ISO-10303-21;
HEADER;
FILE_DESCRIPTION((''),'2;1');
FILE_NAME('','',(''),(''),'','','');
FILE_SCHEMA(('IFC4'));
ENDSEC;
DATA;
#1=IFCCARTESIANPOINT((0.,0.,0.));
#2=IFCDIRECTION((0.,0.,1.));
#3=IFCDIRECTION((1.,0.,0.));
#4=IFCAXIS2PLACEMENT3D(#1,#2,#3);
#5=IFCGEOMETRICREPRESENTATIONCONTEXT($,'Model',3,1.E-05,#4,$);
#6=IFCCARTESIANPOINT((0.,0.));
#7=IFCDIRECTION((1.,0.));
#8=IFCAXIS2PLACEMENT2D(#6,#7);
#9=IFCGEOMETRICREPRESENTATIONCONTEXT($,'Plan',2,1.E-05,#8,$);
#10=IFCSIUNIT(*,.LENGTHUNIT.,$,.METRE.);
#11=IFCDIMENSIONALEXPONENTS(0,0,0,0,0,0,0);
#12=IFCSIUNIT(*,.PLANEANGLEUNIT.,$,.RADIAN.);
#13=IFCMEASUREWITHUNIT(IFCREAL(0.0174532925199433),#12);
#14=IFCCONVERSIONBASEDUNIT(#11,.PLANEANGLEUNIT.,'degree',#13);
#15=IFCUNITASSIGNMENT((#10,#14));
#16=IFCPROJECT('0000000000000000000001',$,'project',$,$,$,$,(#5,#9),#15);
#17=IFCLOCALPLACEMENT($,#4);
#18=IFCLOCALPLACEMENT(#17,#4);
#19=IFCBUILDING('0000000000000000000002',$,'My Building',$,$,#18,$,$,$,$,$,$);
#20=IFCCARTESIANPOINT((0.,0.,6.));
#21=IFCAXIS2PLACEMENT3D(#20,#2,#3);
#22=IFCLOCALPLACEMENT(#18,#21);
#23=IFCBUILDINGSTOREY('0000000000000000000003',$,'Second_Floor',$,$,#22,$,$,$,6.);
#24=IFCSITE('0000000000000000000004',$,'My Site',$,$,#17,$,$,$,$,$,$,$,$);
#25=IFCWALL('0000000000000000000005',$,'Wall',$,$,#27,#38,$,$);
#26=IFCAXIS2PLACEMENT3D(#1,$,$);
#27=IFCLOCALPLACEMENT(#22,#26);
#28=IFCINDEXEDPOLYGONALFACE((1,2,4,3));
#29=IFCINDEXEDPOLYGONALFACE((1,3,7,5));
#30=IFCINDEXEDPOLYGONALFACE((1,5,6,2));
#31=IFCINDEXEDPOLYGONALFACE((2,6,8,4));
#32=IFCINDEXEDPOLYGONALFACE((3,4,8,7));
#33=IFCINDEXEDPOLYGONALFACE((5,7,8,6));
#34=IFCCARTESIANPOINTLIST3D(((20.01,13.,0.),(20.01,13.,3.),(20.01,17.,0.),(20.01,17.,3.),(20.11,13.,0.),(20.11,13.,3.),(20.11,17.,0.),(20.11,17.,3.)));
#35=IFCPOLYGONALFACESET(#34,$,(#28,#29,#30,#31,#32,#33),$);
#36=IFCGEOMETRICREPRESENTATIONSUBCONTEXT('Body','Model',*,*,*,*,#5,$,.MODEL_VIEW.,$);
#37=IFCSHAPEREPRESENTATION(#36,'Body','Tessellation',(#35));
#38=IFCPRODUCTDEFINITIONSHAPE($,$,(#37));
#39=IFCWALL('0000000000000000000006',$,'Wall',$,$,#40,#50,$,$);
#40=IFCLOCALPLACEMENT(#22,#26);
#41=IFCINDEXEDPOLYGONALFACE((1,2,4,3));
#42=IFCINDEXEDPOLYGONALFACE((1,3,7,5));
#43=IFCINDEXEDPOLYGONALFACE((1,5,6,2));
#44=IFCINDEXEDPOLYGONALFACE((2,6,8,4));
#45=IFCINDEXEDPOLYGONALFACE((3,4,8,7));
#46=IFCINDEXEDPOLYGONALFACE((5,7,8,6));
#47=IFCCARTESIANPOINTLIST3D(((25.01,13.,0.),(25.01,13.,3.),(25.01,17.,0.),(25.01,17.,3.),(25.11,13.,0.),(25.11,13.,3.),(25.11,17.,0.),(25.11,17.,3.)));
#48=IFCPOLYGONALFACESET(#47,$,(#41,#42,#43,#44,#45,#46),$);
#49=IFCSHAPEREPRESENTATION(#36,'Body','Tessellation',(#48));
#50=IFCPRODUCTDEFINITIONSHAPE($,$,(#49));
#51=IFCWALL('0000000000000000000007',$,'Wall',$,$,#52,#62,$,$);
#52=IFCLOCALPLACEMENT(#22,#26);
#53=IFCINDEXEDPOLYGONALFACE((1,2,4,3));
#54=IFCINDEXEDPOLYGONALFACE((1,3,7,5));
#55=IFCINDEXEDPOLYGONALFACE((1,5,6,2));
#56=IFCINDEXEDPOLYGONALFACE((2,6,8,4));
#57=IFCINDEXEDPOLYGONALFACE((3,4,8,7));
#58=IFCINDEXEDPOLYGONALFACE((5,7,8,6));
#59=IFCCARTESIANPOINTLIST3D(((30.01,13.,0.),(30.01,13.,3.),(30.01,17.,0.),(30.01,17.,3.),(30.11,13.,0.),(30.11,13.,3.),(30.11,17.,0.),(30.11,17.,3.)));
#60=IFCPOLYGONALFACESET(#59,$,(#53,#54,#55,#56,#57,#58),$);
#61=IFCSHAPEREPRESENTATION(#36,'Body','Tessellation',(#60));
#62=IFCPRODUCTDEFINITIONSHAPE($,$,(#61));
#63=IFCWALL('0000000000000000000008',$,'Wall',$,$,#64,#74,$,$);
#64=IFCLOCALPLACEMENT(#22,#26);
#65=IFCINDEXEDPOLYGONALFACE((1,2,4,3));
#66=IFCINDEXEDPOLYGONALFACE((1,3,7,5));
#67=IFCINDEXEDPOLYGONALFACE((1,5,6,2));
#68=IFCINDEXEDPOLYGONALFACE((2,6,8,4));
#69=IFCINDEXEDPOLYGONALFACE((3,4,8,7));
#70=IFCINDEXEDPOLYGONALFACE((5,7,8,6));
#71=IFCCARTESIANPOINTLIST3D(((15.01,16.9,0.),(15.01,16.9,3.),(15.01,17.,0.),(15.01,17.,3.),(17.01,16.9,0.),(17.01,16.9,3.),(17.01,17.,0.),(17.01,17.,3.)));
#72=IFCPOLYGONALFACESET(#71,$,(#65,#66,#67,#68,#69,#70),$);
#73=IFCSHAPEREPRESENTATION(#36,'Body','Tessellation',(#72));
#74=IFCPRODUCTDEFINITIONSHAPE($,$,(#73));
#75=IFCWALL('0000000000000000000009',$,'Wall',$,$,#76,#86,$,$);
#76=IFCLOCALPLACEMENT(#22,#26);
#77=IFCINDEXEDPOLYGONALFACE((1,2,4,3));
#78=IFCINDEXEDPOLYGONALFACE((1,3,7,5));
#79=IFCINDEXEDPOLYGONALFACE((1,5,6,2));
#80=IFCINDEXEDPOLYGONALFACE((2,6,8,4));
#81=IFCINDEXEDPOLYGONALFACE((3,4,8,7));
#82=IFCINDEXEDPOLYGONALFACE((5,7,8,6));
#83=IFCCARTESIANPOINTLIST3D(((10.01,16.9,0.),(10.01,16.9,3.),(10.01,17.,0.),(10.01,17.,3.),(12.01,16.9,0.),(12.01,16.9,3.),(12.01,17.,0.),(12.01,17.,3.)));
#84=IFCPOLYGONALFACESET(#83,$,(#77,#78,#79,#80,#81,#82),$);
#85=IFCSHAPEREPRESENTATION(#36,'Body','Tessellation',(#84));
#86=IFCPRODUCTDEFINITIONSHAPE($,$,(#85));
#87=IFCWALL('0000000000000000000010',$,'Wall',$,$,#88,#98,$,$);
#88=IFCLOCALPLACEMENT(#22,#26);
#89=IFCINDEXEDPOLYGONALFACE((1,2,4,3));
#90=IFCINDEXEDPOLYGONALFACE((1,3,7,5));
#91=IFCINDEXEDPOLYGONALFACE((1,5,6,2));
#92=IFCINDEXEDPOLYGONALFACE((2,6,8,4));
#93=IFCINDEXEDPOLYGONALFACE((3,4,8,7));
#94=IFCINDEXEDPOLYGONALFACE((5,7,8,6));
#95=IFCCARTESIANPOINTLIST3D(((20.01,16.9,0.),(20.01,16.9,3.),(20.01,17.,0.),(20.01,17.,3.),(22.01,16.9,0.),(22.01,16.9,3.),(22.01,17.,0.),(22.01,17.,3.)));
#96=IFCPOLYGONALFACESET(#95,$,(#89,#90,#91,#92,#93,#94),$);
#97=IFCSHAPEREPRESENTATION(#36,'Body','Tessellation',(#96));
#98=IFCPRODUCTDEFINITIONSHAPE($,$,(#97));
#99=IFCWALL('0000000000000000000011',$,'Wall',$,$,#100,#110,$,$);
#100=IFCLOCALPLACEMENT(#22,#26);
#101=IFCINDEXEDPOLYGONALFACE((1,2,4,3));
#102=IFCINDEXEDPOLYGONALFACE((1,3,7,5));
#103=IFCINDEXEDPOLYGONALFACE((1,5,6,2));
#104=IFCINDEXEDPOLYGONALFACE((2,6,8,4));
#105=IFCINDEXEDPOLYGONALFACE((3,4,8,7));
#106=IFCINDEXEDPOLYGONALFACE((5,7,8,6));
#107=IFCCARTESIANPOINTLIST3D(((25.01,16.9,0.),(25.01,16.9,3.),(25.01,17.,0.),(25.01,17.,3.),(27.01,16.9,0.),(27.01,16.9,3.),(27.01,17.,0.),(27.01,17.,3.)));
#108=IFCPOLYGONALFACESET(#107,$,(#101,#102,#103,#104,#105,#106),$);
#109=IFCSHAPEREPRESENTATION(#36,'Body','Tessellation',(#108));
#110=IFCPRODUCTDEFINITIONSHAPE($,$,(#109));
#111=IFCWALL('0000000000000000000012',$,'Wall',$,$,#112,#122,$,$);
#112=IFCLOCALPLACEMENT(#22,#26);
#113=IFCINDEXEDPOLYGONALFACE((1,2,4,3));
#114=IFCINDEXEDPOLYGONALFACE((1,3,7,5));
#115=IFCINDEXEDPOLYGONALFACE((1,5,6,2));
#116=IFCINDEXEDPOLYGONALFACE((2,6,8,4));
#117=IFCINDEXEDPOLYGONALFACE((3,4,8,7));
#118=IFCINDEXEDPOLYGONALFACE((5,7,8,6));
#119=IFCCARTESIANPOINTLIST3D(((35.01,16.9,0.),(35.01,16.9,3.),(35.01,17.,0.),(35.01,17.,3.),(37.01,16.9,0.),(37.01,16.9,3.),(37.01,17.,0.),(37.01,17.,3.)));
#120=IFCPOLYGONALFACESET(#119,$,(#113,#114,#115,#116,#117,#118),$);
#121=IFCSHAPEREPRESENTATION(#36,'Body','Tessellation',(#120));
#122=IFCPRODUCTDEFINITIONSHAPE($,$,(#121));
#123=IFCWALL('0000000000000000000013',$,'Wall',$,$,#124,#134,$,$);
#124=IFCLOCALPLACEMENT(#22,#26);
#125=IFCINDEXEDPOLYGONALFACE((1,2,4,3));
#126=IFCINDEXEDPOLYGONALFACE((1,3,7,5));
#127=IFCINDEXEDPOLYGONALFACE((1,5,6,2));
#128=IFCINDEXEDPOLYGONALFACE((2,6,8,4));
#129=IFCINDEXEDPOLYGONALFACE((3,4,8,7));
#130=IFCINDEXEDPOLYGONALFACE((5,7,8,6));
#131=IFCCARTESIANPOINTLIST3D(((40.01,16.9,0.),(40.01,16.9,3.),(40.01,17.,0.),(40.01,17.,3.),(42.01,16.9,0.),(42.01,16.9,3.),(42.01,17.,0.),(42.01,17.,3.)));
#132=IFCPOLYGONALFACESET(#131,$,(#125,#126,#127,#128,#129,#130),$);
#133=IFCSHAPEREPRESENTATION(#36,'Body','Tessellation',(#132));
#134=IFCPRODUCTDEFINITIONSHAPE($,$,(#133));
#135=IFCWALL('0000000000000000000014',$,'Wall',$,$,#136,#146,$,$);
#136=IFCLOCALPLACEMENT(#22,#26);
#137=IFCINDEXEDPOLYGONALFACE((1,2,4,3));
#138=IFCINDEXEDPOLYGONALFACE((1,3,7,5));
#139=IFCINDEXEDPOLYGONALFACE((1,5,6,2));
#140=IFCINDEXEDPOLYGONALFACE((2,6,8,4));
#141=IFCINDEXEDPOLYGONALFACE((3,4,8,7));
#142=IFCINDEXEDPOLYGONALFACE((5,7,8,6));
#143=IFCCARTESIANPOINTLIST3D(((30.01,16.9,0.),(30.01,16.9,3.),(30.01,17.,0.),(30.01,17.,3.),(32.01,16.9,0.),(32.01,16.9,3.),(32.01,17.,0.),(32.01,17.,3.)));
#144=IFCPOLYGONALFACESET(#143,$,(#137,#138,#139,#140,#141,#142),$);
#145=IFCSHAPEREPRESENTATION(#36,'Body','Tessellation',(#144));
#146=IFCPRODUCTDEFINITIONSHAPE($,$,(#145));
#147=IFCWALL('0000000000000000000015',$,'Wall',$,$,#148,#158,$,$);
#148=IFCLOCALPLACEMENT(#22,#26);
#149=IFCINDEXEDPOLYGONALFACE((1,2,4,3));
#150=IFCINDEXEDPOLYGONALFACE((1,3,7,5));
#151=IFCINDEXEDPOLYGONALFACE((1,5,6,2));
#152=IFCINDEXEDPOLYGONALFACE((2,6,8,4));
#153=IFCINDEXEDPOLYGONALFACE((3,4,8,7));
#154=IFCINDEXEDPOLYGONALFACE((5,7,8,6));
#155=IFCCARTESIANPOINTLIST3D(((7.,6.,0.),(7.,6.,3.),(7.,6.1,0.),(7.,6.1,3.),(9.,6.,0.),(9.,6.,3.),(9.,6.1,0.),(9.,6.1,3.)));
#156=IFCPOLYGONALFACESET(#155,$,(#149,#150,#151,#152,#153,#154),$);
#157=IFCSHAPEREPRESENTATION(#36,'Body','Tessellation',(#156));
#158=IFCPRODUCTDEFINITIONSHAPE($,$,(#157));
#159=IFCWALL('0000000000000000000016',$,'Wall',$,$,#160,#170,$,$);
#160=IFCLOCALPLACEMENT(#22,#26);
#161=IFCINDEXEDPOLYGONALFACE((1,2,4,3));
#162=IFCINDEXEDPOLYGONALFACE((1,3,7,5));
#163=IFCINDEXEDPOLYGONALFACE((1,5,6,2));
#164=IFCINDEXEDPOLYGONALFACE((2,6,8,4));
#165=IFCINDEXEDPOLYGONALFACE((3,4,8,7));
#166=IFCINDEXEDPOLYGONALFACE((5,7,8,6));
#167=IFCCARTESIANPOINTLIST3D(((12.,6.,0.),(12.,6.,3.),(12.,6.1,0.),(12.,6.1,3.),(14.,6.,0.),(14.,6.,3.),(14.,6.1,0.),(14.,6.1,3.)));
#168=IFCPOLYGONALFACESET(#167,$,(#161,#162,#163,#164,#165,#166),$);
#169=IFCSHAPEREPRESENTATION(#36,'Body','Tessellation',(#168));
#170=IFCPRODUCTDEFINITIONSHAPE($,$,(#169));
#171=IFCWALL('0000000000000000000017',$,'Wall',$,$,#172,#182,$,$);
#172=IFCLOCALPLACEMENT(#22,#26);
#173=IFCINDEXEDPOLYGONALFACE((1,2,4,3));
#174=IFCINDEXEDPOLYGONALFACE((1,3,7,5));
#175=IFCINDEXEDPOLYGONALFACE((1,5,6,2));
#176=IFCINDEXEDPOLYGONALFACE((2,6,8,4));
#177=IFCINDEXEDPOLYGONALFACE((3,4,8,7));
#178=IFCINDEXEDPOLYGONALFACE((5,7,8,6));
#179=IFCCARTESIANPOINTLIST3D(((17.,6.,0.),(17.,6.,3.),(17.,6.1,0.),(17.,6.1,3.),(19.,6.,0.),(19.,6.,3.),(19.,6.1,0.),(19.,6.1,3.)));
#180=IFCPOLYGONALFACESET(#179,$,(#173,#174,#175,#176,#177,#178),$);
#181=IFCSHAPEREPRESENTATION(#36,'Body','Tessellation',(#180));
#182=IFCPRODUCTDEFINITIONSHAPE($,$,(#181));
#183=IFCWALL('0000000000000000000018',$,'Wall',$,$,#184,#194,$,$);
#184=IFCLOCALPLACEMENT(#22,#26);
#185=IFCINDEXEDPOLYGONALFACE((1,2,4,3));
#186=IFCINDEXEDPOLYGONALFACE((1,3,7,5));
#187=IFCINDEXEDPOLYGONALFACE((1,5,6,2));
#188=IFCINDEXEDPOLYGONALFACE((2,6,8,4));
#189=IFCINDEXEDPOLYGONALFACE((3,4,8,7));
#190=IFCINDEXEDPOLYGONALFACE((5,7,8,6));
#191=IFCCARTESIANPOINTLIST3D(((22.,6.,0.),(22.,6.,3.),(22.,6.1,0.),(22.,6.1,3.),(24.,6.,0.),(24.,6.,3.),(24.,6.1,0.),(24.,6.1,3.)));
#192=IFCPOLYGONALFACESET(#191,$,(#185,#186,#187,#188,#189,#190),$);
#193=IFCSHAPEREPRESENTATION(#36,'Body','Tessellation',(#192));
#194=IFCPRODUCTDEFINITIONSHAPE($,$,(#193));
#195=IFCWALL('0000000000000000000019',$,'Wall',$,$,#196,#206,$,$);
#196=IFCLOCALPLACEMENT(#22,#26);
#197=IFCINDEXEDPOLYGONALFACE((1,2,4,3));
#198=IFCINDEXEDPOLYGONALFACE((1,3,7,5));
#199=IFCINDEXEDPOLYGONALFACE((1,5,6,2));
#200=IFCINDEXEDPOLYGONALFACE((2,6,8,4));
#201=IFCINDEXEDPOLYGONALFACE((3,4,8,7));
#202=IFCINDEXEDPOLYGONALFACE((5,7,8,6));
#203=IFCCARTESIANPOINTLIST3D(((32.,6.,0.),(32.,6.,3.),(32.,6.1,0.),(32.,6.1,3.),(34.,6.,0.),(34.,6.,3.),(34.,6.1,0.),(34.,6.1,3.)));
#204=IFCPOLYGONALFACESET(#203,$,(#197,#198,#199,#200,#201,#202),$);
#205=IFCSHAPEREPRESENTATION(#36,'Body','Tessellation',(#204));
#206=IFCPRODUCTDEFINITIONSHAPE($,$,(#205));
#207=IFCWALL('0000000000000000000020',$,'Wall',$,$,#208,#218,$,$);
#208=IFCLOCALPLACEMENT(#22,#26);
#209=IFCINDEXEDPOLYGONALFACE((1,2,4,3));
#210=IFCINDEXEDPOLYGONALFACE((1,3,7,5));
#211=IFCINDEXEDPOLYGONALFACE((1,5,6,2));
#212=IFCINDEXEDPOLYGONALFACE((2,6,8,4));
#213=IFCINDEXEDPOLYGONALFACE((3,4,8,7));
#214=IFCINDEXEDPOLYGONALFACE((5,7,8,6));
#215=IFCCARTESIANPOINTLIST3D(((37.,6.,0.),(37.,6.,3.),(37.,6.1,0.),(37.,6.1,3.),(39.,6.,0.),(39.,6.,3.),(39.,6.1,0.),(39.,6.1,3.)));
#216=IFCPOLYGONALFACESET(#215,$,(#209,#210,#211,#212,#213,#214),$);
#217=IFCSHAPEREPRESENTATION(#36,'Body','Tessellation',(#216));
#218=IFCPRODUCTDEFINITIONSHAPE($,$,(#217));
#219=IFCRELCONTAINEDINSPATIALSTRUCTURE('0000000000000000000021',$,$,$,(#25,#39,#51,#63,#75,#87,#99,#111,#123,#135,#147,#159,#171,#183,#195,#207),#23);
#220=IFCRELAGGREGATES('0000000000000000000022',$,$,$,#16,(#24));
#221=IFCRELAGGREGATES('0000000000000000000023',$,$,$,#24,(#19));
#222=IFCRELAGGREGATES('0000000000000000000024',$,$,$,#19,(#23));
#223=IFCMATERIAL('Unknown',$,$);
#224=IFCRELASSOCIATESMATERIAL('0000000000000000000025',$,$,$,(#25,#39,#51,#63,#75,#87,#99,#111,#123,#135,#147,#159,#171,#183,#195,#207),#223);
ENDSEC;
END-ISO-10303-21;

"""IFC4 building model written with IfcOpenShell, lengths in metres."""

from ifc_helpers import new_model, entity, si_unit, converted_unit, frame, frame_2d, origin, origin_with_axes, origin_2d_with_axis, place, context, subcontext, project, spatial, rectangle, extrude, material, element, save


model = new_model("IFC4")

# Units and contexts
model_context = context("Model", 3, precision=1e-05, world=origin_with_axes())
plan_context = context("Plan", 2, precision=1e-05, world=origin_2d_with_axis())
body_context = subcontext(model_context, "Body", "Model", "MODEL_VIEW")
ifc_project = project(units=[si_unit("LENGTHUNIT", "METRE"), converted_unit("PLANEANGLEUNIT", "degree", entity("IfcReal", 0.0174532925199433), si_unit("PLANEANGLEUNIT", "RADIAN"), dimensions=[0, 0, 0, 0, 0, 0, 0])], contexts=[model_context, plan_context])

# Site, building, storey
site_placement = place(None, origin_with_axes())
site = spatial("IfcSite", under=ifc_project, at=site_placement, Name="My Site")
building_placement = place(site_placement, origin_with_axes())
building = spatial("IfcBuilding", under=site, at=building_placement, Name="My Building")
storey_placement = place(building_placement, frame((0.0, 0.0, 6.0), z_axis=(0.0, 0.0, 1.0), x_axis=(1.0, 0.0, 0.0)))
storey = spatial("IfcBuildingStorey", under=building, at=storey_placement, Name="Second_Floor", Elevation=6.0)

# Shared definitions
ifc_material = material(Name="Unknown")

# Walls
wall_1_placement = place(storey_placement, origin_with_axes())
element("IfcWall", 1, at=wall_1_placement, inside=storey, material=ifc_material, Name="Wall", context=body_context, shape_type="SweptSolid", body=[
    extrude(rectangle(XDim=0.1, YDim=4.0, at=frame_2d((20.06, 15.0))), origin(), (0.0, 0.0, 1.0), 3.0),
])
wall_2_placement = place(storey_placement, origin_with_axes())
element("IfcWall", 2, at=wall_2_placement, inside=storey, material=ifc_material, Name="Wall", context=body_context, shape_type="SweptSolid", body=[
    extrude(rectangle(XDim=0.1, YDim=4.0, at=frame_2d((25.06, 15.0))), origin(), (0.0, 0.0, 1.0), 3.0),
])
wall_3_placement = place(storey_placement, origin_with_axes())
element("IfcWall", 3, at=wall_3_placement, inside=storey, material=ifc_material, Name="Wall", context=body_context, shape_type="SweptSolid", body=[
    extrude(rectangle(XDim=0.1, YDim=4.0, at=frame_2d((30.06, 15.0))), origin(), (0.0, 0.0, 1.0), 3.0),
])
wall_4_placement = place(storey_placement, origin_with_axes())
element("IfcWall", 4, at=wall_4_placement, inside=storey, material=ifc_material, Name="Wall", context=body_context, shape_type="SweptSolid", body=[
    extrude(rectangle(XDim=2.0, YDim=0.1, at=frame_2d((16.01, 16.95))), origin(), (0.0, 0.0, 1.0), 3.0),
])
wall_5_placement = place(storey_placement, origin_with_axes())
element("IfcWall", 5, at=wall_5_placement, inside=storey, material=ifc_material, Name="Wall", context=body_context, shape_type="SweptSolid", body=[
    extrude(rectangle(XDim=2.0, YDim=0.1, at=frame_2d((11.01, 16.95))), origin(), (0.0, 0.0, 1.0), 3.0),
])
wall_6_placement = place(storey_placement, origin_with_axes())
element("IfcWall", 6, at=wall_6_placement, inside=storey, material=ifc_material, Name="Wall", context=body_context, shape_type="SweptSolid", body=[
    extrude(rectangle(XDim=2.0, YDim=0.1, at=frame_2d((21.01, 16.95))), origin(), (0.0, 0.0, 1.0), 3.0),
])
wall_7_placement = place(storey_placement, origin_with_axes())
element("IfcWall", 7, at=wall_7_placement, inside=storey, material=ifc_material, Name="Wall", context=body_context, shape_type="SweptSolid", body=[
    extrude(rectangle(XDim=2.0, YDim=0.1, at=frame_2d((26.01, 16.95))), origin(), (0.0, 0.0, 1.0), 3.0),
])
wall_8_placement = place(storey_placement, origin_with_axes())
element("IfcWall", 8, at=wall_8_placement, inside=storey, material=ifc_material, Name="Wall", context=body_context, shape_type="SweptSolid", body=[
    extrude(rectangle(XDim=2.0, YDim=0.1, at=frame_2d((36.01, 16.95))), origin(), (0.0, 0.0, 1.0), 3.0),
])
wall_9_placement = place(storey_placement, origin_with_axes())
element("IfcWall", 9, at=wall_9_placement, inside=storey, material=ifc_material, Name="Wall", context=body_context, shape_type="SweptSolid", body=[
    extrude(rectangle(XDim=2.0, YDim=0.1, at=frame_2d((41.01, 16.95))), origin(), (0.0, 0.0, 1.0), 3.0),
])
wall_10_placement = place(storey_placement, origin_with_axes())
element("IfcWall", 10, at=wall_10_placement, inside=storey, material=ifc_material, Name="Wall", context=body_context, shape_type="SweptSolid", body=[
    extrude(rectangle(XDim=2.0, YDim=0.1, at=frame_2d((31.01, 16.95))), origin(), (0.0, 0.0, 1.0), 3.0),
])
wall_11_placement = place(storey_placement, origin_with_axes())
element("IfcWall", 11, at=wall_11_placement, inside=storey, material=ifc_material, Name="Wall", context=body_context, shape_type="SweptSolid", body=[
    extrude(rectangle(XDim=2.0, YDim=0.1, at=frame_2d((8.0, 6.05))), origin(), (0.0, 0.0, 1.0), 3.0),
])
wall_12_placement = place(storey_placement, origin_with_axes())
element("IfcWall", 12, at=wall_12_placement, inside=storey, material=ifc_material, Name="Wall", context=body_context, shape_type="SweptSolid", body=[
    extrude(rectangle(XDim=2.0, YDim=0.1, at=frame_2d((13.0, 6.05))), origin(), (0.0, 0.0, 1.0), 3.0),
])
wall_13_placement = place(storey_placement, origin_with_axes())
element("IfcWall", 13, at=wall_13_placement, inside=storey, material=ifc_material, Name="Wall", context=body_context, shape_type="SweptSolid", body=[
    extrude(rectangle(XDim=2.0, YDim=0.1, at=frame_2d((18.0, 6.05))), origin(), (0.0, 0.0, 1.0), 3.0),
])
wall_14_placement = place(storey_placement, origin_with_axes())
element("IfcWall", 14, at=wall_14_placement, inside=storey, material=ifc_material, Name="Wall", context=body_context, shape_type="SweptSolid", body=[
    extrude(rectangle(XDim=2.0, YDim=0.1, at=frame_2d((23.0, 6.05))), origin(), (0.0, 0.0, 1.0), 3.0),
])
wall_15_placement = place(storey_placement, origin_with_axes())
element("IfcWall", 15, at=wall_15_placement, inside=storey, material=ifc_material, Name="Wall", context=body_context, shape_type="SweptSolid", body=[
    extrude(rectangle(XDim=2.0, YDim=0.1, at=frame_2d((33.0, 6.05))), origin(), (0.0, 0.0, 1.0), 3.0),
])
wall_16_placement = place(storey_placement, origin_with_axes())
element("IfcWall", 16, at=wall_16_placement, inside=storey, material=ifc_material, Name="Wall", context=body_context, shape_type="SweptSolid", body=[
    extrude(rectangle(XDim=2.0, YDim=0.1, at=frame_2d((38.0, 6.05))), origin(), (0.0, 0.0, 1.0), 3.0),
])

save(model, "model.ifc")
